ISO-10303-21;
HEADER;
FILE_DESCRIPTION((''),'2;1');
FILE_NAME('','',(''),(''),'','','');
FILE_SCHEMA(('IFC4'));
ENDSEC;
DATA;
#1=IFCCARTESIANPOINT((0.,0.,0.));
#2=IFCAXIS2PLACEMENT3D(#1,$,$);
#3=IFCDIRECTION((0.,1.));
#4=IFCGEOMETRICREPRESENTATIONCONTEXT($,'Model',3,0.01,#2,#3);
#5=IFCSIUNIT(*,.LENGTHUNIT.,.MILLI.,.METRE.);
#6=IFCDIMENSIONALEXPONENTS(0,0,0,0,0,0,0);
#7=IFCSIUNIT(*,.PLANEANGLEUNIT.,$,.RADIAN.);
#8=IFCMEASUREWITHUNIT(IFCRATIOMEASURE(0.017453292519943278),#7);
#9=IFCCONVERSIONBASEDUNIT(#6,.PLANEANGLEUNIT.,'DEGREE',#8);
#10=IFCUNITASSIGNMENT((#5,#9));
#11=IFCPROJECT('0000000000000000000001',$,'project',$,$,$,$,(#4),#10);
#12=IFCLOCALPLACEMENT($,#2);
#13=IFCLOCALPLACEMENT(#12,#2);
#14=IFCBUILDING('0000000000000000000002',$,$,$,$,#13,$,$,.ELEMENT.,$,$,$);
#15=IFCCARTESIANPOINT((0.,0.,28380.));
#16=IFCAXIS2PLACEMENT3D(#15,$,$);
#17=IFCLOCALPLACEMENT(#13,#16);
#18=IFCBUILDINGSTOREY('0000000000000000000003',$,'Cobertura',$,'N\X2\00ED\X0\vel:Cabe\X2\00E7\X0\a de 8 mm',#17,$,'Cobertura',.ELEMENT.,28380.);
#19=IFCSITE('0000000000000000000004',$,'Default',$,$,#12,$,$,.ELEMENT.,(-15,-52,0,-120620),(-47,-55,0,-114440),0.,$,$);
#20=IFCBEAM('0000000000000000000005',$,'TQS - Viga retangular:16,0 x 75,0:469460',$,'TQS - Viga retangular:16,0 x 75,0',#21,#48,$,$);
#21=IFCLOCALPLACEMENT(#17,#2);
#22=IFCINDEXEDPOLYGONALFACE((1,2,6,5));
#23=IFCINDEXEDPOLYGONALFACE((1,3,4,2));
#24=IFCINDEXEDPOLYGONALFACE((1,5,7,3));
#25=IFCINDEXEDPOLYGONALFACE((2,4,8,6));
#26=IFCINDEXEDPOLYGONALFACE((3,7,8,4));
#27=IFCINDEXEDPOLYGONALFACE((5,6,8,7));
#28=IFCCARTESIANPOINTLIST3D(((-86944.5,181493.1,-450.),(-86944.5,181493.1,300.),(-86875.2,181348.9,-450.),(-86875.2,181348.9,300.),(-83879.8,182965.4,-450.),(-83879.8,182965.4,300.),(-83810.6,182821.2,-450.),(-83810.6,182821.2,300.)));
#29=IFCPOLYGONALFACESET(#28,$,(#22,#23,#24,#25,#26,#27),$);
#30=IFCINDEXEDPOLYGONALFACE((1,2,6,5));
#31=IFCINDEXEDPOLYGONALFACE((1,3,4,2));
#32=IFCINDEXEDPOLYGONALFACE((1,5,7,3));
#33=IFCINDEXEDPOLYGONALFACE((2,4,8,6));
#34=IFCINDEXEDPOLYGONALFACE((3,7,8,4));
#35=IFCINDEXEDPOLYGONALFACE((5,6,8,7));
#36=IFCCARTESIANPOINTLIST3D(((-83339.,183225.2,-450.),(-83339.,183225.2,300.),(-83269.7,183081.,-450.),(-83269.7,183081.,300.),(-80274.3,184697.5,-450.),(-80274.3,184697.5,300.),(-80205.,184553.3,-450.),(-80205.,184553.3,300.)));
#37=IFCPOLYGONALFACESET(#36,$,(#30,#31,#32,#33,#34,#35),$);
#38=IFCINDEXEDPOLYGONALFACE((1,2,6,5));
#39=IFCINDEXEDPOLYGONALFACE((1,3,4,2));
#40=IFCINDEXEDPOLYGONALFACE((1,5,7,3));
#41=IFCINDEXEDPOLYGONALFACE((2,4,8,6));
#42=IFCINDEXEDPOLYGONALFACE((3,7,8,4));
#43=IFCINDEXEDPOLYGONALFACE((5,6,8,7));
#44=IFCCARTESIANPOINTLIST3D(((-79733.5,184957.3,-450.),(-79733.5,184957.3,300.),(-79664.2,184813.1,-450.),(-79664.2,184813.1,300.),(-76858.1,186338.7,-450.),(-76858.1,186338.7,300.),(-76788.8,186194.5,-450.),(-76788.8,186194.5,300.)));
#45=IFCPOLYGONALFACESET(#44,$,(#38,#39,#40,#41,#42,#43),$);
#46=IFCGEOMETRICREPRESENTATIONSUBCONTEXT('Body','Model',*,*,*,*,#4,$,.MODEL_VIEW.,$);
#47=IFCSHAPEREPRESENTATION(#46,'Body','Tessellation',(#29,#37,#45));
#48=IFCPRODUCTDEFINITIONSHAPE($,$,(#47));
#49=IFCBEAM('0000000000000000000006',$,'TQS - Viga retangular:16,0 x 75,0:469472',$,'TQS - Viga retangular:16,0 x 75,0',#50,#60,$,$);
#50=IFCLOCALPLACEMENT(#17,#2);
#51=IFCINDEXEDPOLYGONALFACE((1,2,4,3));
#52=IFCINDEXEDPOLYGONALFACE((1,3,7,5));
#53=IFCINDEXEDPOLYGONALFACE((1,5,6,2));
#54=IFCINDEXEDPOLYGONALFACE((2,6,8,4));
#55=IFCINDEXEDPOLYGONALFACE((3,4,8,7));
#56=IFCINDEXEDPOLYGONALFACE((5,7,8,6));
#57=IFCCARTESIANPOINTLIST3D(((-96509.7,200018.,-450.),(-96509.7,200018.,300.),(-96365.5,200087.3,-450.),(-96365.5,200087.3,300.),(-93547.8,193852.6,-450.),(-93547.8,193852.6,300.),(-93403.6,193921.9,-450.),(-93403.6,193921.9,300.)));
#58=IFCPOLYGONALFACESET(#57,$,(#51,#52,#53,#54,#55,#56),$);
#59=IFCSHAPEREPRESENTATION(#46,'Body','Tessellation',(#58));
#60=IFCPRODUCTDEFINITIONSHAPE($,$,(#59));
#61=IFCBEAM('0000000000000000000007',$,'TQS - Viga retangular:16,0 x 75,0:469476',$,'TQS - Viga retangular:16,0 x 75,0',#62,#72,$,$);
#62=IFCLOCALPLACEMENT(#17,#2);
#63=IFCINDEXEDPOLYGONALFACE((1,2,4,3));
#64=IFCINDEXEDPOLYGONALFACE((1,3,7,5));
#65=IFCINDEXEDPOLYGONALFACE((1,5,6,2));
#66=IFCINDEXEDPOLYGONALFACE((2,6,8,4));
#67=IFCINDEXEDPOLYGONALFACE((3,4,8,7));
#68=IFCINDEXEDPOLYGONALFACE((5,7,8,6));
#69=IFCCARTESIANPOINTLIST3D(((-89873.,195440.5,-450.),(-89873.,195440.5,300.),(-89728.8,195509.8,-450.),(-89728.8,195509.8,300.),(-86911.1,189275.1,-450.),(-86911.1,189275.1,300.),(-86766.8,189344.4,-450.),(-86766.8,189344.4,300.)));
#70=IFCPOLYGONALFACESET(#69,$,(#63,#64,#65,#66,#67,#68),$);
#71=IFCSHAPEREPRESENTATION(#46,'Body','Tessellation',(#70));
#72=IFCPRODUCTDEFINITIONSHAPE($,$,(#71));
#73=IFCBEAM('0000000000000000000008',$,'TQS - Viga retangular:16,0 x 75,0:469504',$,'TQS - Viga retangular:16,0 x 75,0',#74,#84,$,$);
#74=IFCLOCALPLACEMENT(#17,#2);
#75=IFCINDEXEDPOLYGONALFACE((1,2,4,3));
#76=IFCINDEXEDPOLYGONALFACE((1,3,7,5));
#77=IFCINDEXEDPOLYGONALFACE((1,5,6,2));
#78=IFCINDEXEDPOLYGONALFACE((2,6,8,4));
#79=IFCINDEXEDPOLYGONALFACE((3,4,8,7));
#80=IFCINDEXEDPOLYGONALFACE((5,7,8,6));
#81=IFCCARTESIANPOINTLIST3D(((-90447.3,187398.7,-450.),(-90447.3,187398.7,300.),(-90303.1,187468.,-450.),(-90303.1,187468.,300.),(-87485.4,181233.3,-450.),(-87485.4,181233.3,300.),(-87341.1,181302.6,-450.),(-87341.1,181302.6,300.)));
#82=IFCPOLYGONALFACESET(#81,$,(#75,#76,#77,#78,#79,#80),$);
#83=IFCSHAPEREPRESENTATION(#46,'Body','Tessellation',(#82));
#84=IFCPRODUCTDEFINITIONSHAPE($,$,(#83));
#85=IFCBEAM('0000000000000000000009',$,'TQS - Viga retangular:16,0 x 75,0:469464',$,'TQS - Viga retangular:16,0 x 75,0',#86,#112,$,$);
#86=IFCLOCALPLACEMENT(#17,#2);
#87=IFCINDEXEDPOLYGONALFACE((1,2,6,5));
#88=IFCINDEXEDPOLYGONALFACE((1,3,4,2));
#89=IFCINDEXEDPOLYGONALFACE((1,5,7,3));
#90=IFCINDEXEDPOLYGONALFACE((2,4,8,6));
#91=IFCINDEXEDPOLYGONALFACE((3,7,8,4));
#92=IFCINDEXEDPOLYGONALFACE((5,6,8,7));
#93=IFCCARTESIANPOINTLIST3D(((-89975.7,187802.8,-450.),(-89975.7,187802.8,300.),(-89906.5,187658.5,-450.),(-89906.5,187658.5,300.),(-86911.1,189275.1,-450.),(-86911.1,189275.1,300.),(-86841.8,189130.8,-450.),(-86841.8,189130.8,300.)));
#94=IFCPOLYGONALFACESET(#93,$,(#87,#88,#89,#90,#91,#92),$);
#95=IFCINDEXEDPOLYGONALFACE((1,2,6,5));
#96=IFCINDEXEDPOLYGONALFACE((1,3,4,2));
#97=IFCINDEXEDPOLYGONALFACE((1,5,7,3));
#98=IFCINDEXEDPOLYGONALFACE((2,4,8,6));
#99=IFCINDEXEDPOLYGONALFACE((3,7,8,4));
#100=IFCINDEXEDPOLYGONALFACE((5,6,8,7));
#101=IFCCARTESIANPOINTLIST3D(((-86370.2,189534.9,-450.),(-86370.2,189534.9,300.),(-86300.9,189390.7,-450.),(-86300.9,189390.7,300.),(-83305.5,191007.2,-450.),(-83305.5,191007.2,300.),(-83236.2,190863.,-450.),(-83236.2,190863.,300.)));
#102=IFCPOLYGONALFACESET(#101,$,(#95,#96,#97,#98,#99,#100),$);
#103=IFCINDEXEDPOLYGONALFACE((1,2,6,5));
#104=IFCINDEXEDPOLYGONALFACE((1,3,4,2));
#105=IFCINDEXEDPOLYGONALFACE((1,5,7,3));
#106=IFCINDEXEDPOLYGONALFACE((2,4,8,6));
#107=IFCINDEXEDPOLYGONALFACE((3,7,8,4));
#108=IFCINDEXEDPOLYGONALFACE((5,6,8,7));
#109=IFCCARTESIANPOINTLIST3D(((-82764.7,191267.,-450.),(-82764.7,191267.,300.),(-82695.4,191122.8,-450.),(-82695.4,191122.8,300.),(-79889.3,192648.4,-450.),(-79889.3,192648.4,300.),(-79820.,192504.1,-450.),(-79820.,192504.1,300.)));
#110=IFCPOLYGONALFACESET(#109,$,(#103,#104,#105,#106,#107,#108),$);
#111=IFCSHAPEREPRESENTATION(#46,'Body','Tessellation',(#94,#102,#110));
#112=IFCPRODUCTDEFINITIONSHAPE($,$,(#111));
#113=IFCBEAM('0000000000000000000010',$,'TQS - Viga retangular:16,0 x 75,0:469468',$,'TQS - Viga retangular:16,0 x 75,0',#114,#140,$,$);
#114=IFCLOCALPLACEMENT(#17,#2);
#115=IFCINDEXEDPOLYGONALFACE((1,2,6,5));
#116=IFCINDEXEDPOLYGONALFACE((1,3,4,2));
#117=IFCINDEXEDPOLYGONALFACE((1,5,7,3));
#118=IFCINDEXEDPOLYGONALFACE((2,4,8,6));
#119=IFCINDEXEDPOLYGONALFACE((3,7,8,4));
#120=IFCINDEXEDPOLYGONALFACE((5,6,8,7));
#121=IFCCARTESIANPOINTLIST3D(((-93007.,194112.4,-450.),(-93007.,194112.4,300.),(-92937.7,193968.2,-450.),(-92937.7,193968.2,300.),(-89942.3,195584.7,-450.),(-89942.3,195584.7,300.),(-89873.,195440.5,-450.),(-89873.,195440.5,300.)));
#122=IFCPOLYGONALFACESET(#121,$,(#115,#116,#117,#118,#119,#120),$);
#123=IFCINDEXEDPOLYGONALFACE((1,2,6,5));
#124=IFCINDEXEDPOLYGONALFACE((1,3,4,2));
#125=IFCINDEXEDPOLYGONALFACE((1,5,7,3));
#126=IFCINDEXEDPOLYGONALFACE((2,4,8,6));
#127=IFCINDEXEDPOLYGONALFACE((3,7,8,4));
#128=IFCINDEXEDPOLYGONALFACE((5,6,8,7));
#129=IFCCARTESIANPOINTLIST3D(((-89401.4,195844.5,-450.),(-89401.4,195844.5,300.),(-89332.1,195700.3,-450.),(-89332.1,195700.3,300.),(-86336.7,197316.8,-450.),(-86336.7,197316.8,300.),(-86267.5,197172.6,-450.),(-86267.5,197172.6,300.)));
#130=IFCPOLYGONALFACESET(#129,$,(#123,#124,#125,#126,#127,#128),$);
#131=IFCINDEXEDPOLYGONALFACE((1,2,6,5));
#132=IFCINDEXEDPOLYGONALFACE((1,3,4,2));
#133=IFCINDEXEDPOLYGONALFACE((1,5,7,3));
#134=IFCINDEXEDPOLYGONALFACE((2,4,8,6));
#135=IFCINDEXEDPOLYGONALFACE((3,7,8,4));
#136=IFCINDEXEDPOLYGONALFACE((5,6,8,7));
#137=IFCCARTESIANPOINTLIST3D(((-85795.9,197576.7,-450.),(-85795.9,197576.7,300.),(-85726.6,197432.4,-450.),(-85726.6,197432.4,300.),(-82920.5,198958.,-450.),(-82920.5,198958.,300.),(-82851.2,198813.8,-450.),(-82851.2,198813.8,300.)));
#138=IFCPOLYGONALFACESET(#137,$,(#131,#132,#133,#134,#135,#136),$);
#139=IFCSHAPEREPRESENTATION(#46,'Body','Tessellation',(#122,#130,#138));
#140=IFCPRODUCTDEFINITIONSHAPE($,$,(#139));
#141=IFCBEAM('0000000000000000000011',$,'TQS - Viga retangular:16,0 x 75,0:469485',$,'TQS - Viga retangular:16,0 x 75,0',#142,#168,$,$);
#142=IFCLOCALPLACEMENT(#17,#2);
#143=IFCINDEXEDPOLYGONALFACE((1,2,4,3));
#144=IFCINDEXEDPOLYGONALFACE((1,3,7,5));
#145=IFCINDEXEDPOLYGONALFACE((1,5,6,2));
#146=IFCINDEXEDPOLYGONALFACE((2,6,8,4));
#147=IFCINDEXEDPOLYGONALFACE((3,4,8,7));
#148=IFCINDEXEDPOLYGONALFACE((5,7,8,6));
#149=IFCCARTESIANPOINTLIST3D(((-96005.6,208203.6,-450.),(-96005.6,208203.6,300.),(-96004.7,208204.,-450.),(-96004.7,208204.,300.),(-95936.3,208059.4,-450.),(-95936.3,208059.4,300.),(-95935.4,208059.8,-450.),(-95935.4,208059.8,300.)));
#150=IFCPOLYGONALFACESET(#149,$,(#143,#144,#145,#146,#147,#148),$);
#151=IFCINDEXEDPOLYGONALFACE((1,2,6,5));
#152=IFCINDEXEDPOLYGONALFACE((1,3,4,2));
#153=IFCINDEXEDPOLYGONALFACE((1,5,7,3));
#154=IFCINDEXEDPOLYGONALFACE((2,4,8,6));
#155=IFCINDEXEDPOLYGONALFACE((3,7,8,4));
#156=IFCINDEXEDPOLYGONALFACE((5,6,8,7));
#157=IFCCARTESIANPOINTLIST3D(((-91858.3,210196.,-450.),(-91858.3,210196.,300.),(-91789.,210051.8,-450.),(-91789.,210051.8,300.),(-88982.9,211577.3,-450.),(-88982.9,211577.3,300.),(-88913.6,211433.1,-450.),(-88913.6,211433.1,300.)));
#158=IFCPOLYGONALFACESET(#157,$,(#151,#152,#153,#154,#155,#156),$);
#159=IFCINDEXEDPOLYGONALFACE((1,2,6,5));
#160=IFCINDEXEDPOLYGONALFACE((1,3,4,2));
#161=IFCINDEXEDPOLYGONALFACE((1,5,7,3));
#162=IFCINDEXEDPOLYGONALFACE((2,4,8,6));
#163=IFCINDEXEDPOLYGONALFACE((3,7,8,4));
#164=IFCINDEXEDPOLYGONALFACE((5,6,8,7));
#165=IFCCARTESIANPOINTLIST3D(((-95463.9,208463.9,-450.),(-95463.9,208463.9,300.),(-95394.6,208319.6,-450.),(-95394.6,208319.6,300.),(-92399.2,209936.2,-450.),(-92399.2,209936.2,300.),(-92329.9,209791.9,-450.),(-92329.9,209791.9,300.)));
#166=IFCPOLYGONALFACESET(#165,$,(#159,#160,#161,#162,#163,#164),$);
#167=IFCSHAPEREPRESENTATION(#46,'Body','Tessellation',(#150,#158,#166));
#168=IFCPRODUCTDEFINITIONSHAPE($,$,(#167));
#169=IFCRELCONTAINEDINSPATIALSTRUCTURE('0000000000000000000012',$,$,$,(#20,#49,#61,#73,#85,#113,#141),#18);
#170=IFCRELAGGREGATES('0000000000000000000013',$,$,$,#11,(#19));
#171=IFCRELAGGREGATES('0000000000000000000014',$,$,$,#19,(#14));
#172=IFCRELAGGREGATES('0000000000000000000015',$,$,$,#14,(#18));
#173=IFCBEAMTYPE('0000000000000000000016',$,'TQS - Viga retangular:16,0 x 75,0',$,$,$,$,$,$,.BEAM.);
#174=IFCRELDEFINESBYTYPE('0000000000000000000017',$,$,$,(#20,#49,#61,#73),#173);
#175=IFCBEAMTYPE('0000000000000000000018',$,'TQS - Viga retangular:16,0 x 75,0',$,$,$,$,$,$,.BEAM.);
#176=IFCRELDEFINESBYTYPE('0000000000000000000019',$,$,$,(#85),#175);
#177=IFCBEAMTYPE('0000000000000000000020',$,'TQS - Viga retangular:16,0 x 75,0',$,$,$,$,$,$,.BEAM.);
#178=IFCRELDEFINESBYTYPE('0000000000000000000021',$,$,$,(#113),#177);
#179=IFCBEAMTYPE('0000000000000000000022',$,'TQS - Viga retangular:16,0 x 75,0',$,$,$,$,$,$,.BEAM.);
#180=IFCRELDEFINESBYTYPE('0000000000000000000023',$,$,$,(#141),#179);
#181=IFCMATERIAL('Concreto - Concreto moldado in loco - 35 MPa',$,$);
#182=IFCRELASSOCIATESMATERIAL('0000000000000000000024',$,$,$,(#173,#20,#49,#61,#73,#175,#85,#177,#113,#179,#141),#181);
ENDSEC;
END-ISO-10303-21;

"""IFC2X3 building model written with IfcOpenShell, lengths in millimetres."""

from ifc_helpers import new_model, entity, si_unit, converted_unit, direction, frame, frame_2d, origin, place, context, subcontext, project, spatial, rectangle, extrude, source, transform, mapped, material, type_object, type_shapes, element, save


model = new_model("IFC2X3")

# Units and contexts
model_context = context("Model", 3, precision=0.01, world=origin(), true_north=direction((0.0, 1.0)))
body_context = subcontext(model_context, "Body", "Model", "MODEL_VIEW")
ifc_project = project(units=[si_unit("LENGTHUNIT", "METRE", prefix="MILLI"), converted_unit("PLANEANGLEUNIT", "DEGREE", entity("IfcRatioMeasure", 0.017453292519943278), si_unit("PLANEANGLEUNIT", "RADIAN"), dimensions=[0, 0, 0, 0, 0, 0, 0])], contexts=[model_context])

# Site, building, storey
site_placement = place(None, origin())
site = spatial("IfcSite", under=ifc_project, at=site_placement, Name="Default", CompositionType="ELEMENT", RefLatitude=(-15, -52, 0, -120620), RefLongitude=(-47, -55, 0, -114440), RefElevation=0.0)
building_placement = place(site_placement, origin())
building = spatial("IfcBuilding", under=site, at=building_placement, CompositionType="ELEMENT")
storey_placement = place(building_placement, frame((0.0, 0.0, 28380.0)))
storey = spatial("IfcBuildingStorey", under=building, at=storey_placement, Name="Cobertura", ObjectType="Nível:Cabeça de 8 mm", LongName="Cobertura", CompositionType="ELEMENT", Elevation=28380.0)

# Beams
ifc_material = material(Name="Concreto - Concreto moldado in loco - 35 MPa")
beam_type_1 = type_object("IfcBeamType", Name="TQS - Viga retangular:16,0 x 75,0", PredefinedType="BEAM", material=ifc_material)
shared_shape_1 = source(origin(), body_context, "Body", "SweptSolid", [
    extrude(rectangle(XDim=750.0, YDim=160.0, at=frame_2d((0.0, 0.0), x_axis=(1.0, 0.0))), frame((-83845.2, 182893.3, 28305.0), z_axis=(-0.90138, -0.43303, 0.0), x_axis=(0.0, 0.0, -1.0)), (0.0, 0.0, 1.0), 3400.0),
    extrude(rectangle(XDim=750.0, YDim=160.0, at=frame_2d((0.0, 0.0), x_axis=(1.0, 0.0))), frame((-80239.7, 184625.4, 28305.0), z_axis=(-0.90138, -0.43303, 0.0), x_axis=(0.0, 0.0, -1.0)), (0.0, 0.0, 1.0), 3400.0),
    extrude(rectangle(XDim=750.0, YDim=160.0, at=frame_2d((0.0, 0.0), x_axis=(1.0, 0.0))), frame((-76823.5, 186266.6, 28305.0), z_axis=(-0.90138, -0.43303, 0.0), x_axis=(0.0, 0.0, -1.0)), (0.0, 0.0, 1.0), 3190.0),
])
type_shapes(beam_type_1, [shared_shape_1])
beam_1_placement = place(storey_placement, frame((0.0, 0.0, -28380.0)))
element("IfcBeam", 1, at=beam_1_placement, inside=storey, type_object=beam_type_1, material=ifc_material, Name="TQS - Viga retangular:16,0 x 75,0:469460", ObjectType="TQS - Viga retangular:16,0 x 75,0", context=body_context, shape_type="MappedRepresentation", body=[
    mapped(shared_shape_1, transform((0.0, 0.0, 0.0), scale=1.0)),
])
beam_2_placement = place(storey_placement, frame((-93441.0, 193815.1, 300.0), z_axis=(0.0, 0.0, 1.0), x_axis=(-0.43303, 0.90138, 0.0)))
element("IfcBeam", 2, at=beam_2_placement, inside=storey, type_object=beam_type_1, material=ifc_material, Name="TQS - Viga retangular:16,0 x 75,0:469472", ObjectType="TQS - Viga retangular:16,0 x 75,0", context=body_context, shape_type="SweptSolid", body=[
    extrude(rectangle(XDim=750.0, YDim=160.0, at=frame_2d((0.0, 0.0), x_axis=(1.0, 0.0))), frame((80.0, 0.0, -375.0), z_axis=(1.0, 0.0, 0.0), x_axis=(0.0, 0.0, -1.0)), (0.0, 0.0, 1.0), 6840.0),
])
beam_3_placement = place(storey_placement, frame((-86804.3, 189237.6, 300.0), z_axis=(0.0, 0.0, 1.0), x_axis=(-0.43303, 0.90138, 0.0)))
element("IfcBeam", 3, at=beam_3_placement, inside=storey, type_object=beam_type_1, material=ifc_material, Name="TQS - Viga retangular:16,0 x 75,0:469476", ObjectType="TQS - Viga retangular:16,0 x 75,0", context=body_context, shape_type="SweptSolid", body=[
    extrude(rectangle(XDim=750.0, YDim=160.0, at=frame_2d((0.0, 0.0), x_axis=(1.0, 0.0))), frame((80.0, 0.0, -375.0), z_axis=(1.0, 0.0, 0.0), x_axis=(0.0, 0.0, -1.0)), (0.0, 0.0, 1.0), 6840.0),
])
beam_4_placement = place(storey_placement, frame((-87378.6, 181195.8, 300.0), z_axis=(0.0, 0.0, 1.0), x_axis=(-0.43303, 0.90138, 0.0)))
element("IfcBeam", 4, at=beam_4_placement, inside=storey, type_object=beam_type_1, material=ifc_material, Name="TQS - Viga retangular:16,0 x 75,0:469504", ObjectType="TQS - Viga retangular:16,0 x 75,0", context=body_context, shape_type="SweptSolid", body=[
    extrude(rectangle(XDim=750.0, YDim=160.0, at=frame_2d((0.0, 0.0), x_axis=(1.0, 0.0))), frame((80.0, 0.0, -375.0), z_axis=(1.0, 0.0, 0.0), x_axis=(0.0, 0.0, -1.0)), (0.0, 0.0, 1.0), 6840.0),
])
beam_type_2 = type_object("IfcBeamType", Name="TQS - Viga retangular:16,0 x 75,0", PredefinedType="BEAM", material=ifc_material)
shared_shape_2 = source(origin(), body_context, "Body", "SweptSolid", [
    extrude(rectangle(XDim=750.0, YDim=160.0, at=frame_2d((0.0, 0.0), x_axis=(1.0, 0.0))), frame((-86876.4, 189203.0, 28305.0), z_axis=(-0.90138, -0.43303, 0.0), x_axis=(0.0, 0.0, -1.0)), (0.0, 0.0, 1.0), 3400.0),
    extrude(rectangle(XDim=750.0, YDim=160.0, at=frame_2d((0.0, 0.0), x_axis=(1.0, 0.0))), frame((-83270.9, 190935.1, 28305.0), z_axis=(-0.90138, -0.43303, 0.0), x_axis=(0.0, 0.0, -1.0)), (0.0, 0.0, 1.0), 3400.0),
    extrude(rectangle(XDim=750.0, YDim=160.0, at=frame_2d((0.0, 0.0), x_axis=(1.0, 0.0))), frame((-79854.7, 192576.3, 28305.0), z_axis=(-0.90138, -0.43303, 0.0), x_axis=(0.0, 0.0, -1.0)), (0.0, 0.0, 1.0), 3190.0),
])
type_shapes(beam_type_2, [shared_shape_2])
beam_5_placement = place(storey_placement, frame((0.0, 0.0, -28380.0)))
element("IfcBeam", 5, at=beam_5_placement, inside=storey, type_object=beam_type_2, material=ifc_material, Name="TQS - Viga retangular:16,0 x 75,0:469464", ObjectType="TQS - Viga retangular:16,0 x 75,0", context=body_context, shape_type="MappedRepresentation", body=[
    mapped(shared_shape_2, transform((0.0, 0.0, 0.0), scale=1.0)),
])
beam_type_3 = type_object("IfcBeamType", Name="TQS - Viga retangular:16,0 x 75,0", PredefinedType="BEAM", material=ifc_material)
shared_shape_3 = source(origin(), body_context, "Body", "SweptSolid", [
    extrude(rectangle(XDim=750.0, YDim=160.0, at=frame_2d((0.0, 0.0), x_axis=(1.0, 0.0))), frame((-89907.6, 195512.6, 28305.0), z_axis=(-0.90138, -0.43303, 0.0), x_axis=(0.0, 0.0, -1.0)), (0.0, 0.0, 1.0), 3400.0),
    extrude(rectangle(XDim=750.0, YDim=160.0, at=frame_2d((0.0, 0.0), x_axis=(1.0, 0.0))), frame((-86302.1, 197244.7, 28305.0), z_axis=(-0.90138, -0.43303, 0.0), x_axis=(0.0, 0.0, -1.0)), (0.0, 0.0, 1.0), 3400.0),
    extrude(rectangle(XDim=750.0, YDim=160.0, at=frame_2d((0.0, 0.0), x_axis=(1.0, 0.0))), frame((-82885.9, 198885.9, 28305.0), z_axis=(-0.90138, -0.43303, 0.0), x_axis=(0.0, 0.0, -1.0)), (0.0, 0.0, 1.0), 3190.0),
])
type_shapes(beam_type_3, [shared_shape_3])
beam_6_placement = place(storey_placement, frame((0.0, 0.0, -28380.0)))
element("IfcBeam", 6, at=beam_6_placement, inside=storey, type_object=beam_type_3, material=ifc_material, Name="TQS - Viga retangular:16,0 x 75,0:469468", ObjectType="TQS - Viga retangular:16,0 x 75,0", context=body_context, shape_type="MappedRepresentation", body=[
    mapped(shared_shape_3, transform((0.0, 0.0, 0.0), scale=1.0)),
])
beam_type_4 = type_object("IfcBeamType", Name="TQS - Viga retangular:16,0 x 75,0", PredefinedType="BEAM", material=ifc_material)
shared_shape_4 = source(origin(), body_context, "Body", "SweptSolid", [
    extrude(rectangle(XDim=750.0, YDim=160.0, at=frame_2d((0.0, 0.0), x_axis=(1.0, 0.0))), frame((-95970.0, 208131.9, 28305.0), z_axis=(-0.90138, -0.43303, 0.0), x_axis=(0.0, 0.0, -1.0)), (0.0, 0.0, 1.0), 1.0),
    extrude(rectangle(XDim=750.0, YDim=160.0, at=frame_2d((0.0, 0.0), x_axis=(1.0, 0.0))), frame((-88948.3, 211505.2, 28305.0), z_axis=(-0.90138, -0.43303, 0.0), x_axis=(0.0, 0.0, -1.0)), (0.0, 0.0, 1.0), 3190.0),
    extrude(rectangle(XDim=750.0, YDim=160.0, at=frame_2d((0.0, 0.0), x_axis=(1.0, 0.0))), frame((-92364.5, 209864.0, 28305.0), z_axis=(-0.90138, -0.43303, 0.0), x_axis=(0.0, 0.0, -1.0)), (0.0, 0.0, 1.0), 3400.0),
])
type_shapes(beam_type_4, [shared_shape_4])
beam_7_placement = place(storey_placement, frame((0.0, 0.0, -28380.0)))
element("IfcBeam", 7, at=beam_7_placement, inside=storey, type_object=beam_type_4, material=ifc_material, Name="TQS - Viga retangular:16,0 x 75,0:469485", ObjectType="TQS - Viga retangular:16,0 x 75,0", context=body_context, shape_type="MappedRepresentation", body=[
    mapped(shared_shape_4, transform((0.0, 0.0, 0.0), scale=1.0)),
])

save(model, "model.ifc")
